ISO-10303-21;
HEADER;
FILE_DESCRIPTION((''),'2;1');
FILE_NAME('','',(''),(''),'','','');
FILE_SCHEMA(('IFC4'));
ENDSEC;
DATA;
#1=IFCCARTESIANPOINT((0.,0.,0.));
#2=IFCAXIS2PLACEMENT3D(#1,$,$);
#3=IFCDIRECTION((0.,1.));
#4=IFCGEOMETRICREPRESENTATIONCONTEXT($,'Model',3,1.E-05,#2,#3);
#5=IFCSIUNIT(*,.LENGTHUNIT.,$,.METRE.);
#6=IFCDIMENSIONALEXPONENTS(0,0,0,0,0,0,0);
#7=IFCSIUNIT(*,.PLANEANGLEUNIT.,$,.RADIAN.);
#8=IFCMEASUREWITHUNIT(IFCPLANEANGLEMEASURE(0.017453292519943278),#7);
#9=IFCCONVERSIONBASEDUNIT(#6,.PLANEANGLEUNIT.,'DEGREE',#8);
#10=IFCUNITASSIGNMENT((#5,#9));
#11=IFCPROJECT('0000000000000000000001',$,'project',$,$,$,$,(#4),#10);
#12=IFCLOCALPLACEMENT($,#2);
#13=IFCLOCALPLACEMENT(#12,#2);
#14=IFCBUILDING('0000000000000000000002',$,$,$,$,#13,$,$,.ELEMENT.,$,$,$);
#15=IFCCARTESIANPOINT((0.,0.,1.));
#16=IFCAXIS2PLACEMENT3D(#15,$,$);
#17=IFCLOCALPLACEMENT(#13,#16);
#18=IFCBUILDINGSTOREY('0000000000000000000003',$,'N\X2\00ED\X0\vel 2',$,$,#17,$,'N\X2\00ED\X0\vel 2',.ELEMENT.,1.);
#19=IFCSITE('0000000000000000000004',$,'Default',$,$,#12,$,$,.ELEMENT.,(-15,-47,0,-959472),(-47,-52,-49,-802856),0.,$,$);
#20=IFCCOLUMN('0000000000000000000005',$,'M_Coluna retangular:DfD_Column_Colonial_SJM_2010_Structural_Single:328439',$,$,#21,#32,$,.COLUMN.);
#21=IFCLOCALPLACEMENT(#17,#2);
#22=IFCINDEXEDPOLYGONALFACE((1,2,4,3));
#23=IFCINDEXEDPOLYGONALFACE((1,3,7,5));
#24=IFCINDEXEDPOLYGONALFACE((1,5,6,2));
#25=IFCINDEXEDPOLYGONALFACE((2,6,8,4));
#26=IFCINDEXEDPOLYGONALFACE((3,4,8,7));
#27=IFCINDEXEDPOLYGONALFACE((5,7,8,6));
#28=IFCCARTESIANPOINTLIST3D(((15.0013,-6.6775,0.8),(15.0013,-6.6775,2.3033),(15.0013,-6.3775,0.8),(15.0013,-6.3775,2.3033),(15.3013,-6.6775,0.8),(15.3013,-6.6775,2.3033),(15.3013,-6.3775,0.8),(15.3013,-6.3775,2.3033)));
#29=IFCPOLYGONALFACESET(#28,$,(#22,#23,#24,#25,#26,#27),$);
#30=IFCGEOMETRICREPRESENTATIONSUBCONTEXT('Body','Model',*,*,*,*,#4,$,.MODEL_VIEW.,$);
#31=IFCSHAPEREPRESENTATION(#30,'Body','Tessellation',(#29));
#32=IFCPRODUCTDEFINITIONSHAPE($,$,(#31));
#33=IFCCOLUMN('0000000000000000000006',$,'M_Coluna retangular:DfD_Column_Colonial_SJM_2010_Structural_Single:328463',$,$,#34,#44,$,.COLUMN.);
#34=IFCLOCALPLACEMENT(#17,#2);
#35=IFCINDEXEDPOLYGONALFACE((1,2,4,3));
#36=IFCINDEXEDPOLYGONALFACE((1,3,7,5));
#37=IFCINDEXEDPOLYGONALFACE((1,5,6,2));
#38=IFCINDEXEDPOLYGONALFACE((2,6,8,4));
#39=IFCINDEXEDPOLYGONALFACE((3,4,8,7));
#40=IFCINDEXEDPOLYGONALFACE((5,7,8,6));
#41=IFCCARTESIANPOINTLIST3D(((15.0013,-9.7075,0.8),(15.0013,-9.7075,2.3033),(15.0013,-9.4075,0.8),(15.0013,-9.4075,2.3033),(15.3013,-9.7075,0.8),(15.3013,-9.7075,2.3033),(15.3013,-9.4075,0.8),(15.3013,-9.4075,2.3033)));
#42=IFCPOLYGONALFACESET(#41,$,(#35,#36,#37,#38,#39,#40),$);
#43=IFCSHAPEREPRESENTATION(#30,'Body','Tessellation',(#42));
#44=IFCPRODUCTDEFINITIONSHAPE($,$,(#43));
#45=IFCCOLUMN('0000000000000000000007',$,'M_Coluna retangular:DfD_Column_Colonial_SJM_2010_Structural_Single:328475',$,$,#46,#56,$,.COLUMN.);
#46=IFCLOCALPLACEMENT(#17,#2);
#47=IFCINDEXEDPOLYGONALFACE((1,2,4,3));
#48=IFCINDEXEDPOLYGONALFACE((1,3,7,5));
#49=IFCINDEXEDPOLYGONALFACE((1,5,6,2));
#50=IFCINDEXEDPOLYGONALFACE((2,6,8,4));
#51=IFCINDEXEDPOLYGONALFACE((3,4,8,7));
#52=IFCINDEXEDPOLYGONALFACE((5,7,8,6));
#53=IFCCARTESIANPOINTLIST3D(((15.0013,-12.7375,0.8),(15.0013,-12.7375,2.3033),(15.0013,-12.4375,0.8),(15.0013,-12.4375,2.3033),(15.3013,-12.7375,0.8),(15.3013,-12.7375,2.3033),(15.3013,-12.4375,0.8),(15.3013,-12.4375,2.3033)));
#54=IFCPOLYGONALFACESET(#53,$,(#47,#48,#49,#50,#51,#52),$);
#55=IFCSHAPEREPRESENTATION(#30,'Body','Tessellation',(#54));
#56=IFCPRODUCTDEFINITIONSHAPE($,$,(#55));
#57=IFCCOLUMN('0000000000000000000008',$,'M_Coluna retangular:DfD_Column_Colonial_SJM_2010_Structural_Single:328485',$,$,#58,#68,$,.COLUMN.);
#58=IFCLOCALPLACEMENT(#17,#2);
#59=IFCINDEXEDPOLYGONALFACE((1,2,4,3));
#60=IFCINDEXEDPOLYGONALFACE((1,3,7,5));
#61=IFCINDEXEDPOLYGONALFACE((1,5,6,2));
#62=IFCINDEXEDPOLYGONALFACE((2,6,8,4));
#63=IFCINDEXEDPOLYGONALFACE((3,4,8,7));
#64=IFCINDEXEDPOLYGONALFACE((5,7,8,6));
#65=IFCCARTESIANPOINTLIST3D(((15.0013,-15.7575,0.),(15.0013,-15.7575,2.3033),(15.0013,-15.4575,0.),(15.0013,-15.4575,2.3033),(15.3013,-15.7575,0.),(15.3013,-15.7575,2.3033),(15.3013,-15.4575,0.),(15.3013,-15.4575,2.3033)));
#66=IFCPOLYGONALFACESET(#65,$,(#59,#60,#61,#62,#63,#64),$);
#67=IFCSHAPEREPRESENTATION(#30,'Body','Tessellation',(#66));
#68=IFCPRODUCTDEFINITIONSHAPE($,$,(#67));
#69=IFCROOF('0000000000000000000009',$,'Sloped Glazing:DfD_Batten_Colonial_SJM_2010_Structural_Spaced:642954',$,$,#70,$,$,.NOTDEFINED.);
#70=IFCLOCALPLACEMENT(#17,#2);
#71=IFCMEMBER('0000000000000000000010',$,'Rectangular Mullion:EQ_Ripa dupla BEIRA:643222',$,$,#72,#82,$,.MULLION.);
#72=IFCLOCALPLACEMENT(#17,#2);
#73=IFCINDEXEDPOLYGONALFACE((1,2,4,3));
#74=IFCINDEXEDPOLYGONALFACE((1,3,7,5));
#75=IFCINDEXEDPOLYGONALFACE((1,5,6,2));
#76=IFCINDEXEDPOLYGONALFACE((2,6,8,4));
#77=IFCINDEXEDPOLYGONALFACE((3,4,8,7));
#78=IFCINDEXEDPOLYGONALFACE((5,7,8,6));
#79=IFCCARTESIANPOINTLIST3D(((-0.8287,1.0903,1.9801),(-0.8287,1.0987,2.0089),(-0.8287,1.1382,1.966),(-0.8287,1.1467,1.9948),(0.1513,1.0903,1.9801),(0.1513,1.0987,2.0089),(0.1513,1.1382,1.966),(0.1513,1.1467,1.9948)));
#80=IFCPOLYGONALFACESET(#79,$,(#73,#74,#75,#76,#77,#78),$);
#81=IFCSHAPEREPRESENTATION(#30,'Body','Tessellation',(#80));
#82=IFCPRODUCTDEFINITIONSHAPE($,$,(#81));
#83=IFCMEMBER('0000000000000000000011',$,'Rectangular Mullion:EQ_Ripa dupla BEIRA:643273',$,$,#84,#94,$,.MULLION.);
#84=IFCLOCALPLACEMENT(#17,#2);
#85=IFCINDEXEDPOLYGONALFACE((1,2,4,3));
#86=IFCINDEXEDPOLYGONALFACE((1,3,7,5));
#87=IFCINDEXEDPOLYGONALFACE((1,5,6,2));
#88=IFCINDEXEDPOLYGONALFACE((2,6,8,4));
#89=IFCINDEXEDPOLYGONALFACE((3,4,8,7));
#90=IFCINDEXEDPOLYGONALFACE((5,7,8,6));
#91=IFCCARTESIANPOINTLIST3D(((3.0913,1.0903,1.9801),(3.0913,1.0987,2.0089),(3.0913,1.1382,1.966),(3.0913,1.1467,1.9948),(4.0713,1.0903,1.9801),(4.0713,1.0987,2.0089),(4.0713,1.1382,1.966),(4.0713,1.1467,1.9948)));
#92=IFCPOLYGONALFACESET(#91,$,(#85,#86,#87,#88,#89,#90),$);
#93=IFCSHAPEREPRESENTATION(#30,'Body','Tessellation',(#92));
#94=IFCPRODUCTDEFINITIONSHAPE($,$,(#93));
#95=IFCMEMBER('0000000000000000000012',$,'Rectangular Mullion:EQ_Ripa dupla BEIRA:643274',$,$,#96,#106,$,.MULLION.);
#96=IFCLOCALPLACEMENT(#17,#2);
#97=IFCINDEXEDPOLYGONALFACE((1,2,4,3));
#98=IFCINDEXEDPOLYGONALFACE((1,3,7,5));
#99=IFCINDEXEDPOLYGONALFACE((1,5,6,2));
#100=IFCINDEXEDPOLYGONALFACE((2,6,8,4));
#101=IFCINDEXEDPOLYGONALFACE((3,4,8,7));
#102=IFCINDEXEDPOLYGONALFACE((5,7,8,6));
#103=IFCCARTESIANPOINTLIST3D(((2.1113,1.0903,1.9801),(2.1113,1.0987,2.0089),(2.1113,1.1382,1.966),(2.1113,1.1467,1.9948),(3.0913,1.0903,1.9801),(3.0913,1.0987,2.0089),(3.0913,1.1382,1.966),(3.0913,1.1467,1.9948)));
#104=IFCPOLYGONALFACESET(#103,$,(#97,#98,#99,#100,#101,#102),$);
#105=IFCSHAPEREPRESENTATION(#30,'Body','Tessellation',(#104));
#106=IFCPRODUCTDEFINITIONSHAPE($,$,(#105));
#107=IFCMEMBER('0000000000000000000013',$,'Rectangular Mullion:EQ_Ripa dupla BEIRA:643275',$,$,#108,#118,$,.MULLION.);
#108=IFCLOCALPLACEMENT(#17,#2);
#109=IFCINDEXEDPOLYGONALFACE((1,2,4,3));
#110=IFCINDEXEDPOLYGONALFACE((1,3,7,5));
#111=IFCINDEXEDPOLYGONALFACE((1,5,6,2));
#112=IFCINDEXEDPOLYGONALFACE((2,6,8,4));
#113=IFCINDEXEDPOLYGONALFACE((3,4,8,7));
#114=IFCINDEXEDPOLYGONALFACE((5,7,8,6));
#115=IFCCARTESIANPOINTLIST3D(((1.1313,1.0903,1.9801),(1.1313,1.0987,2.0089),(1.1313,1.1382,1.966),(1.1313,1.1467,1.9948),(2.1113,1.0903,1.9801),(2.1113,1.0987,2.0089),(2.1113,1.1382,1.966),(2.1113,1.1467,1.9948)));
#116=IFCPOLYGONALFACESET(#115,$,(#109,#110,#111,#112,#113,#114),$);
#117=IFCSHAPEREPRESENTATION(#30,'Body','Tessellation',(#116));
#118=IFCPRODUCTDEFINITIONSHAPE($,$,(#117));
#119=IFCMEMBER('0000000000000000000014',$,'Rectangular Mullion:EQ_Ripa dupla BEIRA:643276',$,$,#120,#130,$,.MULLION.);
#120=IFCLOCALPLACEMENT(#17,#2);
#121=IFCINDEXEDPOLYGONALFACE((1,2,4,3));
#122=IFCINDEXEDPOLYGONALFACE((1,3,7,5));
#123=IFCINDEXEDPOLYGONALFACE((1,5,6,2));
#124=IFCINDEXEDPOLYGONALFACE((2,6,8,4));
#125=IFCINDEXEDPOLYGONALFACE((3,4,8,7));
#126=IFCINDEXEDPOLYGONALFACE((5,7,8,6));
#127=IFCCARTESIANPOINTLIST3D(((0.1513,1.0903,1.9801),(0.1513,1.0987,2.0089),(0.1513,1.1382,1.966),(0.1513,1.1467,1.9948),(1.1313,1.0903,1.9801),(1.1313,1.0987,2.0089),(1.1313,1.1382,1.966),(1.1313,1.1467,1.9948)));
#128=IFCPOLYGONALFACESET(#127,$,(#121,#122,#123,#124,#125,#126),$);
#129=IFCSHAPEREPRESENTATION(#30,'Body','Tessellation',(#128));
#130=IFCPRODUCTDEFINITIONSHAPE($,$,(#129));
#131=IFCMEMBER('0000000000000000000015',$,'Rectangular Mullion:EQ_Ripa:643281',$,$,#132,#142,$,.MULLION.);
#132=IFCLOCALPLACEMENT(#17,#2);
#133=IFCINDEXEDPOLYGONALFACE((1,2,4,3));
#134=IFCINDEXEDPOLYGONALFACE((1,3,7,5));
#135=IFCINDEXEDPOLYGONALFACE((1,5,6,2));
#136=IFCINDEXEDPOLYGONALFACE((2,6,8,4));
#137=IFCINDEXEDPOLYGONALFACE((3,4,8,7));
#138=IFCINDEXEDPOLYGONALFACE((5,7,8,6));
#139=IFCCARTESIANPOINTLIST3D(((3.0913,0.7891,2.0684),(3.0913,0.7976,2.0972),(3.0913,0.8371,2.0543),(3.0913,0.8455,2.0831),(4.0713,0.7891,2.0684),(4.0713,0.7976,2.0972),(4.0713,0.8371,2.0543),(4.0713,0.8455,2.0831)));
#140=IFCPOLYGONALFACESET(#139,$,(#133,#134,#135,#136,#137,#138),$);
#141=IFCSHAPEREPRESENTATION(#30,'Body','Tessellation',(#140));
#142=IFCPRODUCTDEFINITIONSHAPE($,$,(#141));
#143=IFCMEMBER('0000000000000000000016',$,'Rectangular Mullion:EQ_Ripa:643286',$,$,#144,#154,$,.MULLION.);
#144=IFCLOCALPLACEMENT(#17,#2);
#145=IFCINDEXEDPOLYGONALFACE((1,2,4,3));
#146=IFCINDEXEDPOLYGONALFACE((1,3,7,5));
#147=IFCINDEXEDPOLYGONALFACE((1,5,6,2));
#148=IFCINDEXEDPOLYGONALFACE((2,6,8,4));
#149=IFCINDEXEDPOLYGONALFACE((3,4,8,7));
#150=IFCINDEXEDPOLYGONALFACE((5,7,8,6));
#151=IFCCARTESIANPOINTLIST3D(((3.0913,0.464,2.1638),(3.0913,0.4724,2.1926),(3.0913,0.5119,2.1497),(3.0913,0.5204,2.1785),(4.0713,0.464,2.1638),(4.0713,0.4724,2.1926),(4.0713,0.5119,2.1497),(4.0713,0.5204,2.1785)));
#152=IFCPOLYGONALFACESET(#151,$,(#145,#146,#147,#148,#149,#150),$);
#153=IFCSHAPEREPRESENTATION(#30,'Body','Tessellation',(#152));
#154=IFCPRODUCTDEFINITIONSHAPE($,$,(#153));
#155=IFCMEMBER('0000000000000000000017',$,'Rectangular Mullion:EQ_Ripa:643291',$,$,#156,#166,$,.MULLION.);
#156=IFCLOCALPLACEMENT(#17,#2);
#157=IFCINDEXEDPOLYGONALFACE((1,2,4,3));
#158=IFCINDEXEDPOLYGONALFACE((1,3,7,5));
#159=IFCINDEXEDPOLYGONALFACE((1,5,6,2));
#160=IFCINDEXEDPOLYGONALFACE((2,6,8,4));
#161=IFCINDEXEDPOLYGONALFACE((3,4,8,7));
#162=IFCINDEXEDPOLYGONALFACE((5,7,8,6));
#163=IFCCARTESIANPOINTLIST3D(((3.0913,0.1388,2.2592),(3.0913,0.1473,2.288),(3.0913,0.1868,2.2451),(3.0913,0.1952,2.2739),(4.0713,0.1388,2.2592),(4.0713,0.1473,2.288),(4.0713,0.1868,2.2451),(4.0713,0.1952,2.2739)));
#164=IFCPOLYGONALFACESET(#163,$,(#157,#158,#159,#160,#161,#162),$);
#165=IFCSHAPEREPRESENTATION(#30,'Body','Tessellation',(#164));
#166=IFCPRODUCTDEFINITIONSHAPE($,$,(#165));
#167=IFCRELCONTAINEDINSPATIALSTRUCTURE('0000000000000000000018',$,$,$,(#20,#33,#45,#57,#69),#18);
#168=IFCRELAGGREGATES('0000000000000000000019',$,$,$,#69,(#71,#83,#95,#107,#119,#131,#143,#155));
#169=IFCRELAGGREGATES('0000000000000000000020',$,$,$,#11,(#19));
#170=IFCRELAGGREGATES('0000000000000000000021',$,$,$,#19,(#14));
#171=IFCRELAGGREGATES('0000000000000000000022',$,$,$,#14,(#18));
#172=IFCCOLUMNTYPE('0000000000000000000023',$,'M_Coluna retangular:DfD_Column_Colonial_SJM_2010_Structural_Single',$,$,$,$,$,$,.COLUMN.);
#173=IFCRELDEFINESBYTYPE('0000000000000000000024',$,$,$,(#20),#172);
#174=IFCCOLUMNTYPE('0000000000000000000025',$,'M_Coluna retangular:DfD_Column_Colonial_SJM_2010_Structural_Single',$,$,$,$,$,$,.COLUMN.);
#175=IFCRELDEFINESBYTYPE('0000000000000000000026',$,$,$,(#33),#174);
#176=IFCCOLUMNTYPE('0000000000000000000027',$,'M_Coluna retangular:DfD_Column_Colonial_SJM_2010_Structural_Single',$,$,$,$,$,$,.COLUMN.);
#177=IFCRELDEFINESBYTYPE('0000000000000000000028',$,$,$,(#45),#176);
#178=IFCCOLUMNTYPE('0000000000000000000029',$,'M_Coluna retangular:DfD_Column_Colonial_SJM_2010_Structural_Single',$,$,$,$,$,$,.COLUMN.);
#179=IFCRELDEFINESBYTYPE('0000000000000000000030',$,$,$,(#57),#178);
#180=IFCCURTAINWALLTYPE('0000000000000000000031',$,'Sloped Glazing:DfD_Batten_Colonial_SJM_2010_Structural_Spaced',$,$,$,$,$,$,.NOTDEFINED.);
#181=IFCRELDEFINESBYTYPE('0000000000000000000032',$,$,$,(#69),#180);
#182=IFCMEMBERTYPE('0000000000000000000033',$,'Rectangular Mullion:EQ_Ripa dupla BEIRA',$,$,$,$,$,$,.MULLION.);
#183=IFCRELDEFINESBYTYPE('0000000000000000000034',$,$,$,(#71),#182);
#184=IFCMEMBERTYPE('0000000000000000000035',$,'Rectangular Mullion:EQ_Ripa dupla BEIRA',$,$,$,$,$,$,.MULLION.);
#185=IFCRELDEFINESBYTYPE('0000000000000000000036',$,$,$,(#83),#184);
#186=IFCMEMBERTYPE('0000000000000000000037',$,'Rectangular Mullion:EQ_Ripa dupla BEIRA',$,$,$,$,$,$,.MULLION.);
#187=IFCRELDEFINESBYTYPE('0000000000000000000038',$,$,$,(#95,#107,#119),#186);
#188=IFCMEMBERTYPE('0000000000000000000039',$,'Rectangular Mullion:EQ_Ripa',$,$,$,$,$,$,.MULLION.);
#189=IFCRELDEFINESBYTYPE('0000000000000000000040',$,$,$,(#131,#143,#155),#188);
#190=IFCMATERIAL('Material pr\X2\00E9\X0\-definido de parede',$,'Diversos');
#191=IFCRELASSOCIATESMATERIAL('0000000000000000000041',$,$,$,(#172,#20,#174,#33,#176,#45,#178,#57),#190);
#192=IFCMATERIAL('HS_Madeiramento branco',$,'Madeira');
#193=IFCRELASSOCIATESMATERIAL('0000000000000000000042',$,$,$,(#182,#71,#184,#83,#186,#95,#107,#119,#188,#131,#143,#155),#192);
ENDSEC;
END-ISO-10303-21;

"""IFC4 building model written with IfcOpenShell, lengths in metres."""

from ifc_helpers import new_model, entity, si_unit, converted_unit, direction, frame, origin, place, context, subcontext, project, spatial, indexed_curve, outline, extrude, source, transform, mapped, material, type_object, type_shapes, element, aggregate, save


model = new_model("IFC4")

# Units and contexts
model_context = context("Model", 3, precision=1e-05, world=origin(), true_north=direction((0.0, 1.0)))
body_context = subcontext(model_context, "Body", "Model", "MODEL_VIEW")
ifc_project = project(units=[si_unit("LENGTHUNIT", "METRE"), converted_unit("PLANEANGLEUNIT", "DEGREE", entity("IfcPlaneAngleMeasure", 0.017453292519943278), si_unit("PLANEANGLEUNIT", "RADIAN"), dimensions=[0, 0, 0, 0, 0, 0, 0])], contexts=[model_context])

# Site, building, storey
site_placement = place(None, origin())
site = spatial("IfcSite", under=ifc_project, at=site_placement, Name="Default", CompositionType="ELEMENT", RefLatitude=(-15, -47, 0, -959472), RefLongitude=(-47, -52, -49, -802856), RefElevation=0.0)
building_placement = place(site_placement, origin())
building = spatial("IfcBuilding", under=site, at=building_placement, CompositionType="ELEMENT")
storey_placement = place(building_placement, frame((0.0, 0.0, 1.0)))
storey = spatial("IfcBuildingStorey", under=building, at=storey_placement, Name="Nível 2", LongName="Nível 2", CompositionType="ELEMENT", Elevation=1.0)

# Columns
ifc_material_1 = material(Name="Material pré-definido de parede", Category="Diversos")
column_type_1 = type_object("IfcColumnType", Name="M_Coluna retangular:DfD_Column_Colonial_SJM_2010_Structural_Single", PredefinedType="COLUMN", material=ifc_material_1)
shared_shape_1 = source(origin(), body_context, "Body", "SweptSolid", [
    extrude(outline(indexed_curve([(-0.15, -0.15), (0.15, -0.15), (0.15, 0.15), (-0.15, 0.15), (-0.15, -0.15)], self_intersect=False)), frame((15.1513, -6.5275, 1.8), z_axis=(0.0, 0.0, 1.0), x_axis=(0.0, -1.0, 0.0)), (0.0, 0.0, 1.0), 1.5033),
])
type_shapes(column_type_1, [shared_shape_1])
column_1_placement = place(storey_placement, frame((0.0, 0.0, -1.0)))
element("IfcColumn", 1, at=column_1_placement, inside=storey, type_object=column_type_1, material=ifc_material_1, Name="M_Coluna retangular:DfD_Column_Colonial_SJM_2010_Structural_Single:328439", PredefinedType="COLUMN", context=body_context, shape_type="MappedRepresentation", body=[
    mapped(shared_shape_1, transform((0.0, 0.0, 0.0), scale=1.0)),
])
column_type_2 = type_object("IfcColumnType", Name="M_Coluna retangular:DfD_Column_Colonial_SJM_2010_Structural_Single", PredefinedType="COLUMN", material=ifc_material_1)
shared_shape_2 = source(origin(), body_context, "Body", "SweptSolid", [
    extrude(outline(indexed_curve([(-0.15, -0.15), (0.15, -0.15), (0.15, 0.15), (-0.15, 0.15), (-0.15, -0.15)], self_intersect=False)), frame((15.1513, -9.5575, 1.8), z_axis=(0.0, 0.0, 1.0), x_axis=(0.0, -1.0, 0.0)), (0.0, 0.0, 1.0), 1.5033),
])
type_shapes(column_type_2, [shared_shape_2])
column_2_placement = place(storey_placement, frame((0.0, 0.0, -1.0)))
element("IfcColumn", 2, at=column_2_placement, inside=storey, type_object=column_type_2, material=ifc_material_1, Name="M_Coluna retangular:DfD_Column_Colonial_SJM_2010_Structural_Single:328463", PredefinedType="COLUMN", context=body_context, shape_type="MappedRepresentation", body=[
    mapped(shared_shape_2, transform((0.0, 0.0, 0.0), scale=1.0)),
])
column_type_3 = type_object("IfcColumnType", Name="M_Coluna retangular:DfD_Column_Colonial_SJM_2010_Structural_Single", PredefinedType="COLUMN", material=ifc_material_1)
shared_shape_3 = source(origin(), body_context, "Body", "SweptSolid", [
    extrude(outline(indexed_curve([(-0.15, -0.15), (0.15, -0.15), (0.15, 0.15), (-0.15, 0.15), (-0.15, -0.15)], self_intersect=False)), frame((15.1513, -12.5875, 1.8), z_axis=(0.0, 0.0, 1.0), x_axis=(0.0, -1.0, 0.0)), (0.0, 0.0, 1.0), 1.5033),
])
type_shapes(column_type_3, [shared_shape_3])
column_3_placement = place(storey_placement, frame((0.0, 0.0, -1.0)))
element("IfcColumn", 3, at=column_3_placement, inside=storey, type_object=column_type_3, material=ifc_material_1, Name="M_Coluna retangular:DfD_Column_Colonial_SJM_2010_Structural_Single:328475", PredefinedType="COLUMN", context=body_context, shape_type="MappedRepresentation", body=[
    mapped(shared_shape_3, transform((0.0, 0.0, 0.0), scale=1.0)),
])
column_type_4 = type_object("IfcColumnType", Name="M_Coluna retangular:DfD_Column_Colonial_SJM_2010_Structural_Single", PredefinedType="COLUMN", material=ifc_material_1)
shared_shape_4 = source(origin(), body_context, "Body", "SweptSolid", [
    extrude(outline(indexed_curve([(-0.15, -0.15), (0.15, -0.15), (0.15, 0.15), (-0.15, 0.15), (-0.15, -0.15)], self_intersect=False)), frame((15.1513, -15.6075, 1.0), z_axis=(0.0, 0.0, 1.0), x_axis=(-1.0, 0.0, 0.0)), (0.0, 0.0, 1.0), 2.3033),
])
type_shapes(column_type_4, [shared_shape_4])
column_4_placement = place(storey_placement, frame((0.0, 0.0, -1.0)))
element("IfcColumn", 4, at=column_4_placement, inside=storey, type_object=column_type_4, material=ifc_material_1, Name="M_Coluna retangular:DfD_Column_Colonial_SJM_2010_Structural_Single:328485", PredefinedType="COLUMN", context=body_context, shape_type="MappedRepresentation", body=[
    mapped(shared_shape_4, transform((0.0, 0.0, 0.0), scale=1.0)),
])

# Roof, members
curtain_wall_type = type_object("IfcCurtainWallType", Name="Sloped Glazing:DfD_Batten_Colonial_SJM_2010_Structural_Spaced", PredefinedType="NOTDEFINED")
roof_placement = place(storey_placement, frame((0.0, 0.0, -1.0)))
roof = element("IfcRoof", 5, at=roof_placement, inside=storey, type_object=curtain_wall_type, Name="Sloped Glazing:DfD_Batten_Colonial_SJM_2010_Structural_Spaced:642954", PredefinedType="NOTDEFINED")
ifc_material_2 = material(Name="HS_Madeiramento branco", Category="Madeira")
member_type_1 = type_object("IfcMemberType", Name="Rectangular Mullion:EQ_Ripa dupla BEIRA", PredefinedType="MULLION", material=ifc_material_2)
shared_shape_5 = source(origin(), body_context, "Body", "SweptSolid", [
    extrude(outline(indexed_curve([(-0.025, -0.015), (0.025, -0.015), (0.025, 0.015), (-0.025, 0.015), (-0.025, -0.015)], self_intersect=False)), frame((-0.025, 0.0, -0.98), z_axis=(0.0, 0.0, 1.0), x_axis=(-1.0, 0.0, 0.0)), (0.0, 0.0, 1.0), 0.98),
])
type_shapes(member_type_1, [shared_shape_5])
member_1_placement = place(roof_placement, frame((-0.8287, 1.1425, 2.9804), z_axis=(-1.0, 0.0, 0.0), x_axis=(0.0, 0.95956, -0.281504)))
member_1 = element("IfcMember", 6, at=member_1_placement, type_object=member_type_1, material=ifc_material_2, Name="Rectangular Mullion:EQ_Ripa dupla BEIRA:643222", PredefinedType="MULLION", context=body_context, shape_type="MappedRepresentation", body=[
    mapped(shared_shape_5, transform((0.0, 0.0, 0.0), scale=1.0)),
])
member_type_2 = type_object("IfcMemberType", Name="Rectangular Mullion:EQ_Ripa dupla BEIRA", PredefinedType="MULLION", material=ifc_material_2)
shared_shape_6 = source(origin(), body_context, "Body", "SweptSolid", [
    extrude(outline(indexed_curve([(-0.025, -0.015), (0.025, -0.015), (0.025, 0.015), (-0.025, 0.015), (-0.025, -0.015)], self_intersect=False)), frame((-0.025, 0.0, -0.98), z_axis=(0.0, 0.0, 1.0), x_axis=(-1.0, 0.0, 0.0)), (0.0, 0.0, 1.0), 0.98),
])
type_shapes(member_type_2, [shared_shape_6])
member_2_placement = place(roof_placement, frame((3.0913, 1.1425, 2.9804), z_axis=(-1.0, 0.0, 0.0), x_axis=(0.0, 0.95956, -0.281504)))
member_2 = element("IfcMember", 7, at=member_2_placement, type_object=member_type_2, material=ifc_material_2, Name="Rectangular Mullion:EQ_Ripa dupla BEIRA:643273", PredefinedType="MULLION", context=body_context, shape_type="MappedRepresentation", body=[
    mapped(shared_shape_6, transform((0.0, 0.0, 0.0), scale=1.0)),
])
member_type_3 = type_object("IfcMemberType", Name="Rectangular Mullion:EQ_Ripa dupla BEIRA", PredefinedType="MULLION", material=ifc_material_2)
shared_shape_7 = source(origin(), body_context, "Body", "SweptSolid", [
    extrude(outline(indexed_curve([(-0.025, -0.015), (0.025, -0.015), (0.025, 0.015), (-0.025, 0.015), (-0.025, -0.015)], self_intersect=False)), frame((-0.025, 0.0, -0.98), z_axis=(0.0, 0.0, 1.0), x_axis=(-1.0, 0.0, 0.0)), (0.0, 0.0, 1.0), 0.98),
])
type_shapes(member_type_3, [shared_shape_7])
member_3_placement = place(roof_placement, frame((2.1113, 1.1425, 2.9804), z_axis=(-1.0, 0.0, 0.0), x_axis=(0.0, 0.95956, -0.281504)))
member_3 = element("IfcMember", 8, at=member_3_placement, type_object=member_type_3, material=ifc_material_2, Name="Rectangular Mullion:EQ_Ripa dupla BEIRA:643274", PredefinedType="MULLION", context=body_context, shape_type="MappedRepresentation", body=[
    mapped(shared_shape_7, transform((0.0, 0.0, 0.0), scale=1.0)),
])
member_4_placement = place(roof_placement, frame((1.1313, 1.1425, 2.9804), z_axis=(-1.0, 0.0, 0.0), x_axis=(0.0, 0.95956, -0.281504)))
member_4 = element("IfcMember", 9, at=member_4_placement, type_object=member_type_3, material=ifc_material_2, Name="Rectangular Mullion:EQ_Ripa dupla BEIRA:643275", PredefinedType="MULLION", context=body_context, shape_type="MappedRepresentation", body=[
    mapped(shared_shape_7, transform((0.0, 0.0, 0.0), scale=1.0)),
])
member_5_placement = place(roof_placement, frame((0.1513, 1.1425, 2.9804), z_axis=(-1.0, 0.0, 0.0), x_axis=(0.0, 0.95956, -0.281504)))
member_5 = element("IfcMember", 10, at=member_5_placement, type_object=member_type_3, material=ifc_material_2, Name="Rectangular Mullion:EQ_Ripa dupla BEIRA:643276", PredefinedType="MULLION", context=body_context, shape_type="MappedRepresentation", body=[
    mapped(shared_shape_7, transform((0.0, 0.0, 0.0), scale=1.0)),
])
member_type_4 = type_object("IfcMemberType", Name="Rectangular Mullion:EQ_Ripa", PredefinedType="MULLION", material=ifc_material_2)
shared_shape_8 = source(origin(), body_context, "Body", "SweptSolid", [
    extrude(outline(indexed_curve([(-0.025, -0.015), (0.025, -0.015), (0.025, 0.015), (-0.025, 0.015), (-0.025, -0.015)], self_intersect=False)), frame((0.0, 0.0, -0.98), z_axis=(0.0, 0.0, 1.0), x_axis=(-1.0, 0.0, 0.0)), (0.0, 0.0, 1.0), 0.98),
])
type_shapes(member_type_4, [shared_shape_8])
member_6_placement = place(roof_placement, frame((4.0713, 0.8173, 3.0758), z_axis=(1.0, 0.0, 0.0), x_axis=(0.0, -0.95956, 0.281504)))
member_6 = element("IfcMember", 11, at=member_6_placement, type_object=member_type_4, material=ifc_material_2, Name="Rectangular Mullion:EQ_Ripa:643281", PredefinedType="MULLION", context=body_context, shape_type="MappedRepresentation", body=[
    mapped(shared_shape_8, transform((0.0, 0.0, 0.0), scale=1.0)),
])
member_7_placement = place(roof_placement, frame((4.0713, 0.4922, 3.1712), z_axis=(1.0, 0.0, 0.0), x_axis=(0.0, -0.95956, 0.281504)))
member_7 = element("IfcMember", 12, at=member_7_placement, type_object=member_type_4, material=ifc_material_2, Name="Rectangular Mullion:EQ_Ripa:643286", PredefinedType="MULLION", context=body_context, shape_type="MappedRepresentation", body=[
    mapped(shared_shape_8, transform((0.0, 0.0, 0.0), scale=1.0)),
])
member_8_placement = place(roof_placement, frame((4.0713, 0.167, 3.2665), z_axis=(1.0, 0.0, 0.0), x_axis=(0.0, -0.95956, 0.281504)))
member_8 = element("IfcMember", 13, at=member_8_placement, type_object=member_type_4, material=ifc_material_2, Name="Rectangular Mullion:EQ_Ripa:643291", PredefinedType="MULLION", context=body_context, shape_type="MappedRepresentation", body=[
    mapped(shared_shape_8, transform((0.0, 0.0, 0.0), scale=1.0)),
])
aggregate(roof, [member_1, member_2, member_3, member_4, member_5, member_6, member_7, member_8])

save(model, "model.ifc")
